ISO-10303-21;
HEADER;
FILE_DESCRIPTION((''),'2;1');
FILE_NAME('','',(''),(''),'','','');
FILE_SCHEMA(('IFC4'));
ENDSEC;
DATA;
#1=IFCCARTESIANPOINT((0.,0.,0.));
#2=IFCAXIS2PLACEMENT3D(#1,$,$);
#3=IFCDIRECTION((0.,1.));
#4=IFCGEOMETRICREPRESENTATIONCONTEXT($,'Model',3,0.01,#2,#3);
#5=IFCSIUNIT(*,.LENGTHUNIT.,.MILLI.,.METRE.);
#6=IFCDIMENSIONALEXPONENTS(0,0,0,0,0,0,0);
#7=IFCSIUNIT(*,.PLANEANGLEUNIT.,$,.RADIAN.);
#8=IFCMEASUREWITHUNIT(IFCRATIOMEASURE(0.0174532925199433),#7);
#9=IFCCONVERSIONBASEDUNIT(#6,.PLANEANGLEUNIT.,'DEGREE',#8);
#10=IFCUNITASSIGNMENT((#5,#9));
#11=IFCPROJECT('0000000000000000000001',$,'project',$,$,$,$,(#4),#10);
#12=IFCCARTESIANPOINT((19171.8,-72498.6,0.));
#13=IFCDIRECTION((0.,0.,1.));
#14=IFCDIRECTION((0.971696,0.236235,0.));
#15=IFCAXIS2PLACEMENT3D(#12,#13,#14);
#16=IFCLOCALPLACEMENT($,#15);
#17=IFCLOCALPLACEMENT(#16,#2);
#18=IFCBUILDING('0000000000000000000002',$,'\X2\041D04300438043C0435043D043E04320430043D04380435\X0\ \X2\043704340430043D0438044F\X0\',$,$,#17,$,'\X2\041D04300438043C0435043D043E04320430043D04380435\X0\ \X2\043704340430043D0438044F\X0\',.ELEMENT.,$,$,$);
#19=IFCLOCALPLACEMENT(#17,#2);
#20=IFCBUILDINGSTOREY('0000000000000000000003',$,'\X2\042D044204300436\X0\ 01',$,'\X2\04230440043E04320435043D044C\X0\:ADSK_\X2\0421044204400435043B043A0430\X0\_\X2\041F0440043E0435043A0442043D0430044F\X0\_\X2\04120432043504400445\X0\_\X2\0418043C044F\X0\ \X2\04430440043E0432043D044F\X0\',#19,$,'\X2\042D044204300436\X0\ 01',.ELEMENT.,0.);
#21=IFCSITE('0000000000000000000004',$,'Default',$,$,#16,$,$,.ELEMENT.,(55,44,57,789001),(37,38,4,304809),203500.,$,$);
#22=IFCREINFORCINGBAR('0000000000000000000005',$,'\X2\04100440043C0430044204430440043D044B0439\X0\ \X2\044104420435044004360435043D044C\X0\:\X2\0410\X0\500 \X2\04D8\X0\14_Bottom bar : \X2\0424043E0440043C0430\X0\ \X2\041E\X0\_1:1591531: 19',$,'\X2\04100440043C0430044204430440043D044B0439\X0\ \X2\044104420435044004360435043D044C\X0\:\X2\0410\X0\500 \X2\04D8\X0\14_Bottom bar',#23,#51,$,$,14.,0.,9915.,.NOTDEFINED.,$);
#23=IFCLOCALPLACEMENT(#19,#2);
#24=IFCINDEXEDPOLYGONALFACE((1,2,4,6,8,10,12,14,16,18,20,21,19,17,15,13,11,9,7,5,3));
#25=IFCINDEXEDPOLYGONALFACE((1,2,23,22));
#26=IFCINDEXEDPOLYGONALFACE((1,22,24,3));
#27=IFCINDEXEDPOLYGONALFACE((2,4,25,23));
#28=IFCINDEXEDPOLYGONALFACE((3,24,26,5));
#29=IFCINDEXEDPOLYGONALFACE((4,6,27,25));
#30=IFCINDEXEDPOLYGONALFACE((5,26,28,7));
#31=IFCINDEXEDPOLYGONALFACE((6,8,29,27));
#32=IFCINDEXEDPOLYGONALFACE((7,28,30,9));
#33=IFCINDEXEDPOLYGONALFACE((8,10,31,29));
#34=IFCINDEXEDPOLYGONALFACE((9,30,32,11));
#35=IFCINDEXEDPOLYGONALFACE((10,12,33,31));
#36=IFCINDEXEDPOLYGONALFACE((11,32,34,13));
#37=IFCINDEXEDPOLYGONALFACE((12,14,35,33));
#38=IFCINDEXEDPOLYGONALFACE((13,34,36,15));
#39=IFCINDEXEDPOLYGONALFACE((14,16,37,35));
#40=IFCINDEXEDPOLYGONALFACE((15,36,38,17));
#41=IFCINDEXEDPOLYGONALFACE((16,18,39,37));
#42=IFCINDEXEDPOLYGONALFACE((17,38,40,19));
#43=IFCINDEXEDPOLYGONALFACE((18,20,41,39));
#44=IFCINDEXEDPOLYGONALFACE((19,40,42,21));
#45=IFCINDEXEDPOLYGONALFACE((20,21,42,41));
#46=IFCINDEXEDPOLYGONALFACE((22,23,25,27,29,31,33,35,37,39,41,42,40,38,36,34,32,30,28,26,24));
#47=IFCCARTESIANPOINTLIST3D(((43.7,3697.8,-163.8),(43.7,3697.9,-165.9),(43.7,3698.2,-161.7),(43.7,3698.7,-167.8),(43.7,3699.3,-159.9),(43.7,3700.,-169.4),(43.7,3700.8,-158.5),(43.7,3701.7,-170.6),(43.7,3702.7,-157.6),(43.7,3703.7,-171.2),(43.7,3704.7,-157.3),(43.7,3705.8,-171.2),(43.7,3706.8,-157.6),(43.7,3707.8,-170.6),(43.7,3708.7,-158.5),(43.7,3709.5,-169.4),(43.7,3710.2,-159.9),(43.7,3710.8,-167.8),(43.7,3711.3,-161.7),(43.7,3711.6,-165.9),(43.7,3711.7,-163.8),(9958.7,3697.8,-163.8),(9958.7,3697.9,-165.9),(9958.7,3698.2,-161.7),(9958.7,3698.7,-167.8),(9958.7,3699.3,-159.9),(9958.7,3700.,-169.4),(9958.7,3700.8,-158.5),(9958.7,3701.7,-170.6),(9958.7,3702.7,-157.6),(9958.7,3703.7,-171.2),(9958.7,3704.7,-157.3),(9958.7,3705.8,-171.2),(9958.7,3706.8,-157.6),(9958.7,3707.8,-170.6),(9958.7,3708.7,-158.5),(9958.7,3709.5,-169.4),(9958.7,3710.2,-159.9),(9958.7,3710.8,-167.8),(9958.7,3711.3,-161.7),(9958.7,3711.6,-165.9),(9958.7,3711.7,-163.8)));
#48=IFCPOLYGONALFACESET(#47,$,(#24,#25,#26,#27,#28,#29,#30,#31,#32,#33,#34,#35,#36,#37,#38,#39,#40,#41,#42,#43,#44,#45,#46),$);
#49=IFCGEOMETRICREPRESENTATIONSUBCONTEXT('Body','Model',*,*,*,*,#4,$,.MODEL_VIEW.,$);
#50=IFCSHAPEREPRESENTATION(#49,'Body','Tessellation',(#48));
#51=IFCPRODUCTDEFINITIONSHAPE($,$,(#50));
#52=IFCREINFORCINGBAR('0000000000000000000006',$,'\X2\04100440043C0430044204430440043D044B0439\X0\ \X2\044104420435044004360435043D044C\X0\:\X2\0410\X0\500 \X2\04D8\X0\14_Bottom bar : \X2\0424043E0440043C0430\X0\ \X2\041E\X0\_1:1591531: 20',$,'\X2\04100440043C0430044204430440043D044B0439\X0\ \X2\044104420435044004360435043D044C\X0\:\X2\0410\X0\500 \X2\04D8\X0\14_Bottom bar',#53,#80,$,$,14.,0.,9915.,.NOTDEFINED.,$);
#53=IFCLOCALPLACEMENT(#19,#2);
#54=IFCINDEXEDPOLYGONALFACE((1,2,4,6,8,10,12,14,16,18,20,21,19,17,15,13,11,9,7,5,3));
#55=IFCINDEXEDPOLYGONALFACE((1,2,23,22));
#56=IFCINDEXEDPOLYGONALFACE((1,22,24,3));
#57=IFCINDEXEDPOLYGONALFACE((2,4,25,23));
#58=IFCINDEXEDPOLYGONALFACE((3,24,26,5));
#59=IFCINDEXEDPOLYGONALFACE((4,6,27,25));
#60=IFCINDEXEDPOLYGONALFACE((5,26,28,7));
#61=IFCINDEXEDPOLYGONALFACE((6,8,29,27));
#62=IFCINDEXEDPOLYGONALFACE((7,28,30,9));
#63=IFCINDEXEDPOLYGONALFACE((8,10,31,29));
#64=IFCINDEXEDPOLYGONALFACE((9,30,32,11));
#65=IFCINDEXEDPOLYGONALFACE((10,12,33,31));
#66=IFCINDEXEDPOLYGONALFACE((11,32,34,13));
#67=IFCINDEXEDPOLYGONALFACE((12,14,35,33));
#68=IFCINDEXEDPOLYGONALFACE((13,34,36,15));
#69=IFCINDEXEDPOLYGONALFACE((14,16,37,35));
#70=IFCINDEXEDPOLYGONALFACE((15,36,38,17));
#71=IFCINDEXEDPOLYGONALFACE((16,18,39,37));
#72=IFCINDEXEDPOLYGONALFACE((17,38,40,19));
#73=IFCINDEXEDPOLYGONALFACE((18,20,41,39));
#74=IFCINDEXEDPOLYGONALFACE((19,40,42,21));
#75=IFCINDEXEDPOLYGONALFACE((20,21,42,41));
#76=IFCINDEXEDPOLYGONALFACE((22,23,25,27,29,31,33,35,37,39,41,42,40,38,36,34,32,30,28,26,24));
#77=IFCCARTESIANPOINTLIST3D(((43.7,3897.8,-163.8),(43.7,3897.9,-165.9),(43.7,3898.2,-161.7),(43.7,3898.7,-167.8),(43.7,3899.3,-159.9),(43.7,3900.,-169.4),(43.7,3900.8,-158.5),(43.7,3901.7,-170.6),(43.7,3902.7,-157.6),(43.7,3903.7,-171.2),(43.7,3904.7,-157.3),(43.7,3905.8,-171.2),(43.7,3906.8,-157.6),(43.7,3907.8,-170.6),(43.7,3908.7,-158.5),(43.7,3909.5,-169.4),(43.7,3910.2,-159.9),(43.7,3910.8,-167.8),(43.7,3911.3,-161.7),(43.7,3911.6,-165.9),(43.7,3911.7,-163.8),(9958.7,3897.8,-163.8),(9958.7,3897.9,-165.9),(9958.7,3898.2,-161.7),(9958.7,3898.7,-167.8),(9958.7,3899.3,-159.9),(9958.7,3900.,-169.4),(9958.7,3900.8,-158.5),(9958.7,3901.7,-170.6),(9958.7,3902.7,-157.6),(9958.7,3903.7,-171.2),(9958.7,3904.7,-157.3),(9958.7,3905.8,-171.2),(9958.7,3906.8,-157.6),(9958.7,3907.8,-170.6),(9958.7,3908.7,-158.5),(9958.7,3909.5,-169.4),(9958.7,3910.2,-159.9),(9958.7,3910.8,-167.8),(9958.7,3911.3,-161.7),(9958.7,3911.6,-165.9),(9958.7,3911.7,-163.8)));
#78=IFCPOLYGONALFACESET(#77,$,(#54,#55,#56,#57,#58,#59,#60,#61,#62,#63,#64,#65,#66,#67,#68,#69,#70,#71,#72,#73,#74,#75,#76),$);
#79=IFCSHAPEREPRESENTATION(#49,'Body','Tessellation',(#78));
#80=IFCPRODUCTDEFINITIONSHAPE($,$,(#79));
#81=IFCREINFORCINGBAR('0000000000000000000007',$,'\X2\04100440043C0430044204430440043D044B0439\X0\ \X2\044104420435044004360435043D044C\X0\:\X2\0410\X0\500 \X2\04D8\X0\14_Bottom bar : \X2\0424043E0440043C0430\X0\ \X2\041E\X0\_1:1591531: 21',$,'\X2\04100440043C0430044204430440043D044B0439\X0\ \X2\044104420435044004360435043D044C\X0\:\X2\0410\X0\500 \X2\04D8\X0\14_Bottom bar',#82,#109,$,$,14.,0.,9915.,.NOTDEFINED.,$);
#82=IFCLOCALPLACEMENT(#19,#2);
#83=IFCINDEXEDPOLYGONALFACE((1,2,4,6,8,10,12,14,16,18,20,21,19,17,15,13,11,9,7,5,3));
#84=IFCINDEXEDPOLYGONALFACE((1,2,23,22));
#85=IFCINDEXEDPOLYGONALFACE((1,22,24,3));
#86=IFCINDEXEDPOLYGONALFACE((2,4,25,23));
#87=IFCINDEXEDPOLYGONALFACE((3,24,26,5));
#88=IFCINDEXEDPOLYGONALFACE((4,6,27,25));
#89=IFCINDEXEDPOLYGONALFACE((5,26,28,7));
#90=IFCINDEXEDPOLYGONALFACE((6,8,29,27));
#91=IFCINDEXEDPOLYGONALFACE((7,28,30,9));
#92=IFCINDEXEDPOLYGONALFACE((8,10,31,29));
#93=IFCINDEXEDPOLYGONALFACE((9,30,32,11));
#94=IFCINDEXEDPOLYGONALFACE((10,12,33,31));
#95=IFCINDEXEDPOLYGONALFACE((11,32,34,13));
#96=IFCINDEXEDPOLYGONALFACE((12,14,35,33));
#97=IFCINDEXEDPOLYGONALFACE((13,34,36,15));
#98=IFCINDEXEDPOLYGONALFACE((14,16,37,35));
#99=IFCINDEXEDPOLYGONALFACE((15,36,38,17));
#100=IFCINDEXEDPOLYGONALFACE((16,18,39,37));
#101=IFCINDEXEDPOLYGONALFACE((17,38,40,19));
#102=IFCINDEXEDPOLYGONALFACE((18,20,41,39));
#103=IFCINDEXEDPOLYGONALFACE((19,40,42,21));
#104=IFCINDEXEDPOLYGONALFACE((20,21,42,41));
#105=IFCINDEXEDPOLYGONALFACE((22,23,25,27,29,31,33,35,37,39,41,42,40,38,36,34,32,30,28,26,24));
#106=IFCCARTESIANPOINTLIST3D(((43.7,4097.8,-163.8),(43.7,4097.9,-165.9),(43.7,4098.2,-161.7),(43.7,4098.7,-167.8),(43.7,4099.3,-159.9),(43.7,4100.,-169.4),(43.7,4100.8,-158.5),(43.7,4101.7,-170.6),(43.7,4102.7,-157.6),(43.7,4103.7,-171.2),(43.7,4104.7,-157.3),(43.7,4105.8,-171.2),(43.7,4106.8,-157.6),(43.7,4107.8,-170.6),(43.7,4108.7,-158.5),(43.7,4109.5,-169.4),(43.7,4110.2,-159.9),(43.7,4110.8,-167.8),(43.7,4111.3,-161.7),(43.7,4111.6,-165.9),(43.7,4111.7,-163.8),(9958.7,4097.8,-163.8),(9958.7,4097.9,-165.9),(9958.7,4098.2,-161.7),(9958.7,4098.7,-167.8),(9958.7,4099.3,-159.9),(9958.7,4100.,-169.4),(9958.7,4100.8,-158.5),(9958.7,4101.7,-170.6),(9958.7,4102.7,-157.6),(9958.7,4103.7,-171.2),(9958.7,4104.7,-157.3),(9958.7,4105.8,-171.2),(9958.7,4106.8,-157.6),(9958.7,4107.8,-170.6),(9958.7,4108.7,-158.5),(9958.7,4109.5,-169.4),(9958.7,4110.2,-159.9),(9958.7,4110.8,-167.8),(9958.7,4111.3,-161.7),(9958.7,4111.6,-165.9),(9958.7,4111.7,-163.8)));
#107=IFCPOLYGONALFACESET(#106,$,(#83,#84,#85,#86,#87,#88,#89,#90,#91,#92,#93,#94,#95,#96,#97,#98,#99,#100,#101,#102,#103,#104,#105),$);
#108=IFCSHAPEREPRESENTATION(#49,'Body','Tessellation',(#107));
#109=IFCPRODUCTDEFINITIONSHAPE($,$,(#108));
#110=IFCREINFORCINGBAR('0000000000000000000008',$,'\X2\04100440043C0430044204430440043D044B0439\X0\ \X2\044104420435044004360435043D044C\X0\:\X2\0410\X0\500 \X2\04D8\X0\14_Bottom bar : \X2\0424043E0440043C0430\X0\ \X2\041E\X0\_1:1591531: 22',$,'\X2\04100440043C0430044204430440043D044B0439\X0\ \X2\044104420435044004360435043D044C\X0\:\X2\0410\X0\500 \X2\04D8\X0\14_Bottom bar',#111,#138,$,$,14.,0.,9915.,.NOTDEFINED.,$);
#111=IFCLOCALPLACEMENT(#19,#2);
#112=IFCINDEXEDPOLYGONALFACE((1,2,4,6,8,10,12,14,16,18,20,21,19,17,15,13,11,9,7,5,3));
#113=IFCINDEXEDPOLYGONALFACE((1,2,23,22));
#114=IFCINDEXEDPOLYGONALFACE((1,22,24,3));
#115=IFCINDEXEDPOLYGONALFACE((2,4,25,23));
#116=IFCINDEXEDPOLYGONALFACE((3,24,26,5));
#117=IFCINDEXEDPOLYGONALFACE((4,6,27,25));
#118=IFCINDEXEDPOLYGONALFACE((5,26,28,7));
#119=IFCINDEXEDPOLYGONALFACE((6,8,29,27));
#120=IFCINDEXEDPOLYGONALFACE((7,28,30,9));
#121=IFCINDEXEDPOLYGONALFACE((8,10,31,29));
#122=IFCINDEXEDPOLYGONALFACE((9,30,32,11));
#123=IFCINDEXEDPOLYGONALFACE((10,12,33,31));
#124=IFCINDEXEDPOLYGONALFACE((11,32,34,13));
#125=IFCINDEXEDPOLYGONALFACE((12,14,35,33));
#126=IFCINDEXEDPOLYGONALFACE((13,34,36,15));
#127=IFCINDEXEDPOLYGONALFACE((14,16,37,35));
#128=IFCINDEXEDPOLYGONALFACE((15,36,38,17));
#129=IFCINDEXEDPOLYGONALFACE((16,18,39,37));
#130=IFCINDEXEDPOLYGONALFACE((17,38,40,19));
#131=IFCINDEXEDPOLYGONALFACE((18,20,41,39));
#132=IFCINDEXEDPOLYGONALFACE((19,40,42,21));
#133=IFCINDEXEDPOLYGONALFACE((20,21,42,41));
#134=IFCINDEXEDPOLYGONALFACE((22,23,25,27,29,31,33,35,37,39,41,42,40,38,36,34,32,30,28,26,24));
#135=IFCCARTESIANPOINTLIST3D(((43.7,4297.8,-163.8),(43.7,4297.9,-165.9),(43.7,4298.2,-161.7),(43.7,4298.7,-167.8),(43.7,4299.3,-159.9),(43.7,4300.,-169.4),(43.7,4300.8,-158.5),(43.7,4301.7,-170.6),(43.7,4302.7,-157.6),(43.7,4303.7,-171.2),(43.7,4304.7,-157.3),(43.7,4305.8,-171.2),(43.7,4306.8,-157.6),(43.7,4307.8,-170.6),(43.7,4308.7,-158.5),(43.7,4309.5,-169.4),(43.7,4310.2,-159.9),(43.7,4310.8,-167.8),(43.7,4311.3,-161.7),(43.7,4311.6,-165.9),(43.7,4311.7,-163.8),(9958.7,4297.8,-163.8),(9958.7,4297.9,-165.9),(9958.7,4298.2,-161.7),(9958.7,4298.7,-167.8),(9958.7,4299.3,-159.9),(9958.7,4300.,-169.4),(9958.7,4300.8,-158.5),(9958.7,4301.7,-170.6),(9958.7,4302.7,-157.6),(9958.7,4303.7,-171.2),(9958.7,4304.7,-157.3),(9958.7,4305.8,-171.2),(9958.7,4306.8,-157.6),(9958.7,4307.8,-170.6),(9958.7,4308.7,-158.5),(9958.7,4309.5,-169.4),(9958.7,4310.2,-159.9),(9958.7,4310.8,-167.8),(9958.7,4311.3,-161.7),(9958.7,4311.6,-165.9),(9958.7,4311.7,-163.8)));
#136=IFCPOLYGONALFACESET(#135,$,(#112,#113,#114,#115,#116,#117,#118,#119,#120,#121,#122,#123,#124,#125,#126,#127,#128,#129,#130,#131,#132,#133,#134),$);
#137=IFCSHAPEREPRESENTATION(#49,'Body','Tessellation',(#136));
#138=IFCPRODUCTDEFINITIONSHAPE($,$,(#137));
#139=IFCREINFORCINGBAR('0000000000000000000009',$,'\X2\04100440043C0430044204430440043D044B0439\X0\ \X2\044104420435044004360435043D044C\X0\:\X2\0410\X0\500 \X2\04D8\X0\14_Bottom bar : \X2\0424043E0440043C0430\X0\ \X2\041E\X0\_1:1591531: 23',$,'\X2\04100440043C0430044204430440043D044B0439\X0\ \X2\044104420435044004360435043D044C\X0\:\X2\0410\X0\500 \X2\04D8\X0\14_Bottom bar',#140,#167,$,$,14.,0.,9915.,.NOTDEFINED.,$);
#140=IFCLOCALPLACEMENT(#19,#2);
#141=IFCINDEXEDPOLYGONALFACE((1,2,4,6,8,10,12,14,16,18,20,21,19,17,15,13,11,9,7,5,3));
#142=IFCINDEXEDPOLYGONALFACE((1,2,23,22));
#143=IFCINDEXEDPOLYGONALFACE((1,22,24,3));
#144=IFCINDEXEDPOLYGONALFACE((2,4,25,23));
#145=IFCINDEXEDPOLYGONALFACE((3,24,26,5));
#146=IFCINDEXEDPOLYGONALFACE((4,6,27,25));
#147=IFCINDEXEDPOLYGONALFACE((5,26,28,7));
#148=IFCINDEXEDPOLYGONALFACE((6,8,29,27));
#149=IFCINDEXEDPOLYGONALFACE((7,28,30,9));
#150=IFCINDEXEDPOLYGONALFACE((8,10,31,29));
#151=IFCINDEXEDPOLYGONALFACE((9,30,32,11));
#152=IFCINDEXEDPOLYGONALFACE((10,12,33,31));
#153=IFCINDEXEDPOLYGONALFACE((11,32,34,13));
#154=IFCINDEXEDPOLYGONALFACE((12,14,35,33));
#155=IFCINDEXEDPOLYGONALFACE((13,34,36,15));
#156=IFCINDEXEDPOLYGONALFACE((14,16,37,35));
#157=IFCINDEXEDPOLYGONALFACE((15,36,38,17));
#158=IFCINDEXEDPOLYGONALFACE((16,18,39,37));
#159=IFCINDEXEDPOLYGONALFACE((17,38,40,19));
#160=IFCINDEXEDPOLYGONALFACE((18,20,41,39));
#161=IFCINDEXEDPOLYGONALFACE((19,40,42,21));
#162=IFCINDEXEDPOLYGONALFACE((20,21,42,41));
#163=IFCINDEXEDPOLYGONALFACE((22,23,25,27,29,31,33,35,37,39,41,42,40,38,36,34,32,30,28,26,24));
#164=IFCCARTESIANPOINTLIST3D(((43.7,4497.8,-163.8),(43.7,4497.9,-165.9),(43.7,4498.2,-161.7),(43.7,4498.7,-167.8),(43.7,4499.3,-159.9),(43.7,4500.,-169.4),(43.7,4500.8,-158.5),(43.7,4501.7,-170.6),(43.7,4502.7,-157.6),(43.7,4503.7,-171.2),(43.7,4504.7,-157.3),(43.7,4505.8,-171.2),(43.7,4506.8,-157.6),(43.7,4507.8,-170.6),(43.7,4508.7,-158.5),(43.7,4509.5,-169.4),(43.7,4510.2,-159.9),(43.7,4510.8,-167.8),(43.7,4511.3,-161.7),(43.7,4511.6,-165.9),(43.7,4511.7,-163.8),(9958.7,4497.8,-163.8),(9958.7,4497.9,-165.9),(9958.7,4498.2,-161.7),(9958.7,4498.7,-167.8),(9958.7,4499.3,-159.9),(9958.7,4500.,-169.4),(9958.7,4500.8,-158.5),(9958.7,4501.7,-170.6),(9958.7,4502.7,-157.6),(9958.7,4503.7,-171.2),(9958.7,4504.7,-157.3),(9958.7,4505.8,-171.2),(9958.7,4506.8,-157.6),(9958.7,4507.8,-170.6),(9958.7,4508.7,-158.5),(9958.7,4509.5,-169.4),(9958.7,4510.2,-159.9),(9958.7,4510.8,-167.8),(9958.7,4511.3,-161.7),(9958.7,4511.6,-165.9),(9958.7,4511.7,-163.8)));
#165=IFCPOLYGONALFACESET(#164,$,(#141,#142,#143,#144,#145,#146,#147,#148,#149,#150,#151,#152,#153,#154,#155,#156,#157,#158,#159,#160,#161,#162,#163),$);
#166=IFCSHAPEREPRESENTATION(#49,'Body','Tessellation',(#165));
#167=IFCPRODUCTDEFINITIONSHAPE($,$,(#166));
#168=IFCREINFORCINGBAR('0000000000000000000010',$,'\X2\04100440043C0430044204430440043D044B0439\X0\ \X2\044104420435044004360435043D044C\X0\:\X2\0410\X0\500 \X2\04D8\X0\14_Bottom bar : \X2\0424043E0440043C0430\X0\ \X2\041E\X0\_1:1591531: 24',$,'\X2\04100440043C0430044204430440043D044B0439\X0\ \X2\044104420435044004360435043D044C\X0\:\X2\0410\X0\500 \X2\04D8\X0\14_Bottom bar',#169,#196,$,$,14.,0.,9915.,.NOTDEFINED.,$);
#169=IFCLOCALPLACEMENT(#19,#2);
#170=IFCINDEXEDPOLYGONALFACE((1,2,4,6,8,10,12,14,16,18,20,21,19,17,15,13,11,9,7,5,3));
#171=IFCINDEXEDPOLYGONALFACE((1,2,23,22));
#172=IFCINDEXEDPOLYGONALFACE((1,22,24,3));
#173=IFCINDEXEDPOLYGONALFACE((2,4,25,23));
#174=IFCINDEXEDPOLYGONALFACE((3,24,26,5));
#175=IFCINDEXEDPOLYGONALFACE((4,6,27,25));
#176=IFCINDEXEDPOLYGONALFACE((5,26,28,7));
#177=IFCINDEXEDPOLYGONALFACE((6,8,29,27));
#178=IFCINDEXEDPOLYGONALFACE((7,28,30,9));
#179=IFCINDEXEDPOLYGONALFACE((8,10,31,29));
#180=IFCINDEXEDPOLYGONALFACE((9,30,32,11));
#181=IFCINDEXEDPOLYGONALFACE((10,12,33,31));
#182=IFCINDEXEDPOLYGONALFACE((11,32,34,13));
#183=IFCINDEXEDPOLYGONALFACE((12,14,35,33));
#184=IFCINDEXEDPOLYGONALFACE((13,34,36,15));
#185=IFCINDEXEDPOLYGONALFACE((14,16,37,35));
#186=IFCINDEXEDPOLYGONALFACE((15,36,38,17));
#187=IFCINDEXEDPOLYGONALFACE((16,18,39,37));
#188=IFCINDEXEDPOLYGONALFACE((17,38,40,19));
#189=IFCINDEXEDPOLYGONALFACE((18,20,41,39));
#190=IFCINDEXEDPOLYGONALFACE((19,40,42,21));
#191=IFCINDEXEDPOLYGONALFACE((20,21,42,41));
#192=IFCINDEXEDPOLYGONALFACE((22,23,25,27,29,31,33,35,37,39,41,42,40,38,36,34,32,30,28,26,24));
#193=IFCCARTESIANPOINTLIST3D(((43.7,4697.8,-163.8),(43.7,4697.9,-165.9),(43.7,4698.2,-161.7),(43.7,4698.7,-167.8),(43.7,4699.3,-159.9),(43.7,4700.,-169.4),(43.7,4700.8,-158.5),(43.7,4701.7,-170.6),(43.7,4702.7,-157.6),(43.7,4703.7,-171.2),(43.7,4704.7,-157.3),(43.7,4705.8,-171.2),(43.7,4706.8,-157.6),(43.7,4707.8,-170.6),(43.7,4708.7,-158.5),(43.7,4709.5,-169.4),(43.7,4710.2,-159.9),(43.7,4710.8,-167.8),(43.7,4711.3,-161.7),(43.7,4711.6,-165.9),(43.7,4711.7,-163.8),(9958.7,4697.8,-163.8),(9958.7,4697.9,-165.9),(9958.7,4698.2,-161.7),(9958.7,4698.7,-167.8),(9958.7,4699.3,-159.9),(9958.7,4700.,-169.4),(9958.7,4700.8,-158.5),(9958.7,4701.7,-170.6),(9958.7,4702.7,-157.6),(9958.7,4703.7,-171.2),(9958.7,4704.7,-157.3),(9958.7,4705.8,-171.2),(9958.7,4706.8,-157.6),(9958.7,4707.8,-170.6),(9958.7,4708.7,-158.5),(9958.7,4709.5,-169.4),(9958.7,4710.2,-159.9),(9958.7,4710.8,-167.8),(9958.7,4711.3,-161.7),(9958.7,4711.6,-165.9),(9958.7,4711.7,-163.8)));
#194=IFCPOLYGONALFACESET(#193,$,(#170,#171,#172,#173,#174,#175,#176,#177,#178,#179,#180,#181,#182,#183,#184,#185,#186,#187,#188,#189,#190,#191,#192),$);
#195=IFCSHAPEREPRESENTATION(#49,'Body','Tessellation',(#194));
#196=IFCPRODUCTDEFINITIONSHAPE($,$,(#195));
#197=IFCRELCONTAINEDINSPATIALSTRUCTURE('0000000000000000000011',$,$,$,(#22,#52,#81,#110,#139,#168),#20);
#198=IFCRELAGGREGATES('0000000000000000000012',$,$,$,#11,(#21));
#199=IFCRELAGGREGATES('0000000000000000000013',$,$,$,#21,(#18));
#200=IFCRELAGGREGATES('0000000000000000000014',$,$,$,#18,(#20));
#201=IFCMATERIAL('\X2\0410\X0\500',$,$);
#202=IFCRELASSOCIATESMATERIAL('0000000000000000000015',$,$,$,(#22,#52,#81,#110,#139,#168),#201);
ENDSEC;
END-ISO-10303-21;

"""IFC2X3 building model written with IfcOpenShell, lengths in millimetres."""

from ifc_helpers import new_model, entity, si_unit, converted_unit, direction, frame, origin, place, context, subcontext, project, spatial, material, element, save


model = new_model("IFC2X3")

# Units and contexts
model_context = context("Model", 3, precision=0.01, world=origin(), true_north=direction((0.0, 1.0)))
body_context = subcontext(model_context, "Body", "Model", "MODEL_VIEW")
ifc_project = project(units=[si_unit("LENGTHUNIT", "METRE", prefix="MILLI"), converted_unit("PLANEANGLEUNIT", "DEGREE", entity("IfcRatioMeasure", 0.0174532925199433), si_unit("PLANEANGLEUNIT", "RADIAN"), dimensions=[0, 0, 0, 0, 0, 0, 0])], contexts=[model_context])

# Site, building, storey
site_placement = place(None, frame((19171.8, -72498.6, 0.0), z_axis=(0.0, 0.0, 1.0), x_axis=(0.971696, 0.236235, 0.0)))
site = spatial("IfcSite", under=ifc_project, at=site_placement, Name="Default", CompositionType="ELEMENT", RefLatitude=(55, 44, 57, 789001), RefLongitude=(37, 38, 4, 304809), RefElevation=203500.0)
building_placement = place(site_placement, origin())
building = spatial("IfcBuilding", under=site, at=building_placement, Name="Наименование здания", LongName="Наименование здания", CompositionType="ELEMENT")
storey_placement = place(building_placement, origin())
storey = spatial("IfcBuildingStorey", under=building, at=storey_placement, Name="Этаж 01", ObjectType="Уровень:ADSK_Стрелка_Проектная_Вверх_Имя уровня", LongName="Этаж 01", CompositionType="ELEMENT", Elevation=0.0)

# Reinforcing bars
ifc_material = material(Name="А500")
placement = place(storey_placement, origin())
element("IfcReinforcingBar", 1, at=placement, inside=storey, material=ifc_material, Name="Арматурный стержень:А500 Ә14_Bottom bar : Форма О_1:1591531: 19", ObjectType="Арматурный стержень:А500 Ә14_Bottom bar", BarLength=9915.0, BarRole="NOTDEFINED", CrossSectionArea=0.0, NominalDiameter=14.0, context=body_context, shape_type="AdvancedSweptSolid", body=[
    entity("IfcSweptDiskSolid", entity("IfcCompositeCurve", [entity("IfcCompositeCurveSegment", "CONTINUOUS", True, entity("IfcPolyline", [entity("IfcCartesianPoint", [43.7, 3704.7, -164.3]), entity("IfcCartesianPoint", [9958.7, 3704.7, -164.3])]))], False), 7.0, None, 0.0, 1.0),
])
element("IfcReinforcingBar", 2, at=placement, inside=storey, material=ifc_material, Name="Арматурный стержень:А500 Ә14_Bottom bar : Форма О_1:1591531: 20", ObjectType="Арматурный стержень:А500 Ә14_Bottom bar", BarLength=9915.0, BarRole="NOTDEFINED", CrossSectionArea=0.0, NominalDiameter=14.0, context=body_context, shape_type="AdvancedSweptSolid", body=[
    entity("IfcSweptDiskSolid", entity("IfcCompositeCurve", [entity("IfcCompositeCurveSegment", "CONTINUOUS", True, entity("IfcPolyline", [entity("IfcCartesianPoint", [43.7, 3904.7, -164.3]), entity("IfcCartesianPoint", [9958.7, 3904.7, -164.3])]))], False), 7.0, None, 0.0, 1.0),
])
element("IfcReinforcingBar", 3, at=placement, inside=storey, material=ifc_material, Name="Арматурный стержень:А500 Ә14_Bottom bar : Форма О_1:1591531: 21", ObjectType="Арматурный стержень:А500 Ә14_Bottom bar", BarLength=9915.0, BarRole="NOTDEFINED", CrossSectionArea=0.0, NominalDiameter=14.0, context=body_context, shape_type="AdvancedSweptSolid", body=[
    entity("IfcSweptDiskSolid", entity("IfcCompositeCurve", [entity("IfcCompositeCurveSegment", "CONTINUOUS", True, entity("IfcPolyline", [entity("IfcCartesianPoint", [43.7, 4104.7, -164.3]), entity("IfcCartesianPoint", [9958.7, 4104.7, -164.3])]))], False), 7.0, None, 0.0, 1.0),
])
element("IfcReinforcingBar", 4, at=placement, inside=storey, material=ifc_material, Name="Арматурный стержень:А500 Ә14_Bottom bar : Форма О_1:1591531: 22", ObjectType="Арматурный стержень:А500 Ә14_Bottom bar", BarLength=9915.0, BarRole="NOTDEFINED", CrossSectionArea=0.0, NominalDiameter=14.0, context=body_context, shape_type="AdvancedSweptSolid", body=[
    entity("IfcSweptDiskSolid", entity("IfcCompositeCurve", [entity("IfcCompositeCurveSegment", "CONTINUOUS", True, entity("IfcPolyline", [entity("IfcCartesianPoint", [43.7, 4304.7, -164.3]), entity("IfcCartesianPoint", [9958.7, 4304.7, -164.3])]))], False), 7.0, None, 0.0, 1.0),
])
element("IfcReinforcingBar", 5, at=placement, inside=storey, material=ifc_material, Name="Арматурный стержень:А500 Ә14_Bottom bar : Форма О_1:1591531: 23", ObjectType="Арматурный стержень:А500 Ә14_Bottom bar", BarLength=9915.0, BarRole="NOTDEFINED", CrossSectionArea=0.0, NominalDiameter=14.0, context=body_context, shape_type="AdvancedSweptSolid", body=[
    entity("IfcSweptDiskSolid", entity("IfcCompositeCurve", [entity("IfcCompositeCurveSegment", "CONTINUOUS", True, entity("IfcPolyline", [entity("IfcCartesianPoint", [43.7, 4504.7, -164.3]), entity("IfcCartesianPoint", [9958.7, 4504.7, -164.3])]))], False), 7.0, None, 0.0, 1.0),
])
element("IfcReinforcingBar", 6, at=placement, inside=storey, material=ifc_material, Name="Арматурный стержень:А500 Ә14_Bottom bar : Форма О_1:1591531: 24", ObjectType="Арматурный стержень:А500 Ә14_Bottom bar", BarLength=9915.0, BarRole="NOTDEFINED", CrossSectionArea=0.0, NominalDiameter=14.0, context=body_context, shape_type="AdvancedSweptSolid", body=[
    entity("IfcSweptDiskSolid", entity("IfcCompositeCurve", [entity("IfcCompositeCurveSegment", "CONTINUOUS", True, entity("IfcPolyline", [entity("IfcCartesianPoint", [43.7, 4704.7, -164.3]), entity("IfcCartesianPoint", [9958.7, 4704.7, -164.3])]))], False), 7.0, None, 0.0, 1.0),
])

save(model, "model.ifc")
